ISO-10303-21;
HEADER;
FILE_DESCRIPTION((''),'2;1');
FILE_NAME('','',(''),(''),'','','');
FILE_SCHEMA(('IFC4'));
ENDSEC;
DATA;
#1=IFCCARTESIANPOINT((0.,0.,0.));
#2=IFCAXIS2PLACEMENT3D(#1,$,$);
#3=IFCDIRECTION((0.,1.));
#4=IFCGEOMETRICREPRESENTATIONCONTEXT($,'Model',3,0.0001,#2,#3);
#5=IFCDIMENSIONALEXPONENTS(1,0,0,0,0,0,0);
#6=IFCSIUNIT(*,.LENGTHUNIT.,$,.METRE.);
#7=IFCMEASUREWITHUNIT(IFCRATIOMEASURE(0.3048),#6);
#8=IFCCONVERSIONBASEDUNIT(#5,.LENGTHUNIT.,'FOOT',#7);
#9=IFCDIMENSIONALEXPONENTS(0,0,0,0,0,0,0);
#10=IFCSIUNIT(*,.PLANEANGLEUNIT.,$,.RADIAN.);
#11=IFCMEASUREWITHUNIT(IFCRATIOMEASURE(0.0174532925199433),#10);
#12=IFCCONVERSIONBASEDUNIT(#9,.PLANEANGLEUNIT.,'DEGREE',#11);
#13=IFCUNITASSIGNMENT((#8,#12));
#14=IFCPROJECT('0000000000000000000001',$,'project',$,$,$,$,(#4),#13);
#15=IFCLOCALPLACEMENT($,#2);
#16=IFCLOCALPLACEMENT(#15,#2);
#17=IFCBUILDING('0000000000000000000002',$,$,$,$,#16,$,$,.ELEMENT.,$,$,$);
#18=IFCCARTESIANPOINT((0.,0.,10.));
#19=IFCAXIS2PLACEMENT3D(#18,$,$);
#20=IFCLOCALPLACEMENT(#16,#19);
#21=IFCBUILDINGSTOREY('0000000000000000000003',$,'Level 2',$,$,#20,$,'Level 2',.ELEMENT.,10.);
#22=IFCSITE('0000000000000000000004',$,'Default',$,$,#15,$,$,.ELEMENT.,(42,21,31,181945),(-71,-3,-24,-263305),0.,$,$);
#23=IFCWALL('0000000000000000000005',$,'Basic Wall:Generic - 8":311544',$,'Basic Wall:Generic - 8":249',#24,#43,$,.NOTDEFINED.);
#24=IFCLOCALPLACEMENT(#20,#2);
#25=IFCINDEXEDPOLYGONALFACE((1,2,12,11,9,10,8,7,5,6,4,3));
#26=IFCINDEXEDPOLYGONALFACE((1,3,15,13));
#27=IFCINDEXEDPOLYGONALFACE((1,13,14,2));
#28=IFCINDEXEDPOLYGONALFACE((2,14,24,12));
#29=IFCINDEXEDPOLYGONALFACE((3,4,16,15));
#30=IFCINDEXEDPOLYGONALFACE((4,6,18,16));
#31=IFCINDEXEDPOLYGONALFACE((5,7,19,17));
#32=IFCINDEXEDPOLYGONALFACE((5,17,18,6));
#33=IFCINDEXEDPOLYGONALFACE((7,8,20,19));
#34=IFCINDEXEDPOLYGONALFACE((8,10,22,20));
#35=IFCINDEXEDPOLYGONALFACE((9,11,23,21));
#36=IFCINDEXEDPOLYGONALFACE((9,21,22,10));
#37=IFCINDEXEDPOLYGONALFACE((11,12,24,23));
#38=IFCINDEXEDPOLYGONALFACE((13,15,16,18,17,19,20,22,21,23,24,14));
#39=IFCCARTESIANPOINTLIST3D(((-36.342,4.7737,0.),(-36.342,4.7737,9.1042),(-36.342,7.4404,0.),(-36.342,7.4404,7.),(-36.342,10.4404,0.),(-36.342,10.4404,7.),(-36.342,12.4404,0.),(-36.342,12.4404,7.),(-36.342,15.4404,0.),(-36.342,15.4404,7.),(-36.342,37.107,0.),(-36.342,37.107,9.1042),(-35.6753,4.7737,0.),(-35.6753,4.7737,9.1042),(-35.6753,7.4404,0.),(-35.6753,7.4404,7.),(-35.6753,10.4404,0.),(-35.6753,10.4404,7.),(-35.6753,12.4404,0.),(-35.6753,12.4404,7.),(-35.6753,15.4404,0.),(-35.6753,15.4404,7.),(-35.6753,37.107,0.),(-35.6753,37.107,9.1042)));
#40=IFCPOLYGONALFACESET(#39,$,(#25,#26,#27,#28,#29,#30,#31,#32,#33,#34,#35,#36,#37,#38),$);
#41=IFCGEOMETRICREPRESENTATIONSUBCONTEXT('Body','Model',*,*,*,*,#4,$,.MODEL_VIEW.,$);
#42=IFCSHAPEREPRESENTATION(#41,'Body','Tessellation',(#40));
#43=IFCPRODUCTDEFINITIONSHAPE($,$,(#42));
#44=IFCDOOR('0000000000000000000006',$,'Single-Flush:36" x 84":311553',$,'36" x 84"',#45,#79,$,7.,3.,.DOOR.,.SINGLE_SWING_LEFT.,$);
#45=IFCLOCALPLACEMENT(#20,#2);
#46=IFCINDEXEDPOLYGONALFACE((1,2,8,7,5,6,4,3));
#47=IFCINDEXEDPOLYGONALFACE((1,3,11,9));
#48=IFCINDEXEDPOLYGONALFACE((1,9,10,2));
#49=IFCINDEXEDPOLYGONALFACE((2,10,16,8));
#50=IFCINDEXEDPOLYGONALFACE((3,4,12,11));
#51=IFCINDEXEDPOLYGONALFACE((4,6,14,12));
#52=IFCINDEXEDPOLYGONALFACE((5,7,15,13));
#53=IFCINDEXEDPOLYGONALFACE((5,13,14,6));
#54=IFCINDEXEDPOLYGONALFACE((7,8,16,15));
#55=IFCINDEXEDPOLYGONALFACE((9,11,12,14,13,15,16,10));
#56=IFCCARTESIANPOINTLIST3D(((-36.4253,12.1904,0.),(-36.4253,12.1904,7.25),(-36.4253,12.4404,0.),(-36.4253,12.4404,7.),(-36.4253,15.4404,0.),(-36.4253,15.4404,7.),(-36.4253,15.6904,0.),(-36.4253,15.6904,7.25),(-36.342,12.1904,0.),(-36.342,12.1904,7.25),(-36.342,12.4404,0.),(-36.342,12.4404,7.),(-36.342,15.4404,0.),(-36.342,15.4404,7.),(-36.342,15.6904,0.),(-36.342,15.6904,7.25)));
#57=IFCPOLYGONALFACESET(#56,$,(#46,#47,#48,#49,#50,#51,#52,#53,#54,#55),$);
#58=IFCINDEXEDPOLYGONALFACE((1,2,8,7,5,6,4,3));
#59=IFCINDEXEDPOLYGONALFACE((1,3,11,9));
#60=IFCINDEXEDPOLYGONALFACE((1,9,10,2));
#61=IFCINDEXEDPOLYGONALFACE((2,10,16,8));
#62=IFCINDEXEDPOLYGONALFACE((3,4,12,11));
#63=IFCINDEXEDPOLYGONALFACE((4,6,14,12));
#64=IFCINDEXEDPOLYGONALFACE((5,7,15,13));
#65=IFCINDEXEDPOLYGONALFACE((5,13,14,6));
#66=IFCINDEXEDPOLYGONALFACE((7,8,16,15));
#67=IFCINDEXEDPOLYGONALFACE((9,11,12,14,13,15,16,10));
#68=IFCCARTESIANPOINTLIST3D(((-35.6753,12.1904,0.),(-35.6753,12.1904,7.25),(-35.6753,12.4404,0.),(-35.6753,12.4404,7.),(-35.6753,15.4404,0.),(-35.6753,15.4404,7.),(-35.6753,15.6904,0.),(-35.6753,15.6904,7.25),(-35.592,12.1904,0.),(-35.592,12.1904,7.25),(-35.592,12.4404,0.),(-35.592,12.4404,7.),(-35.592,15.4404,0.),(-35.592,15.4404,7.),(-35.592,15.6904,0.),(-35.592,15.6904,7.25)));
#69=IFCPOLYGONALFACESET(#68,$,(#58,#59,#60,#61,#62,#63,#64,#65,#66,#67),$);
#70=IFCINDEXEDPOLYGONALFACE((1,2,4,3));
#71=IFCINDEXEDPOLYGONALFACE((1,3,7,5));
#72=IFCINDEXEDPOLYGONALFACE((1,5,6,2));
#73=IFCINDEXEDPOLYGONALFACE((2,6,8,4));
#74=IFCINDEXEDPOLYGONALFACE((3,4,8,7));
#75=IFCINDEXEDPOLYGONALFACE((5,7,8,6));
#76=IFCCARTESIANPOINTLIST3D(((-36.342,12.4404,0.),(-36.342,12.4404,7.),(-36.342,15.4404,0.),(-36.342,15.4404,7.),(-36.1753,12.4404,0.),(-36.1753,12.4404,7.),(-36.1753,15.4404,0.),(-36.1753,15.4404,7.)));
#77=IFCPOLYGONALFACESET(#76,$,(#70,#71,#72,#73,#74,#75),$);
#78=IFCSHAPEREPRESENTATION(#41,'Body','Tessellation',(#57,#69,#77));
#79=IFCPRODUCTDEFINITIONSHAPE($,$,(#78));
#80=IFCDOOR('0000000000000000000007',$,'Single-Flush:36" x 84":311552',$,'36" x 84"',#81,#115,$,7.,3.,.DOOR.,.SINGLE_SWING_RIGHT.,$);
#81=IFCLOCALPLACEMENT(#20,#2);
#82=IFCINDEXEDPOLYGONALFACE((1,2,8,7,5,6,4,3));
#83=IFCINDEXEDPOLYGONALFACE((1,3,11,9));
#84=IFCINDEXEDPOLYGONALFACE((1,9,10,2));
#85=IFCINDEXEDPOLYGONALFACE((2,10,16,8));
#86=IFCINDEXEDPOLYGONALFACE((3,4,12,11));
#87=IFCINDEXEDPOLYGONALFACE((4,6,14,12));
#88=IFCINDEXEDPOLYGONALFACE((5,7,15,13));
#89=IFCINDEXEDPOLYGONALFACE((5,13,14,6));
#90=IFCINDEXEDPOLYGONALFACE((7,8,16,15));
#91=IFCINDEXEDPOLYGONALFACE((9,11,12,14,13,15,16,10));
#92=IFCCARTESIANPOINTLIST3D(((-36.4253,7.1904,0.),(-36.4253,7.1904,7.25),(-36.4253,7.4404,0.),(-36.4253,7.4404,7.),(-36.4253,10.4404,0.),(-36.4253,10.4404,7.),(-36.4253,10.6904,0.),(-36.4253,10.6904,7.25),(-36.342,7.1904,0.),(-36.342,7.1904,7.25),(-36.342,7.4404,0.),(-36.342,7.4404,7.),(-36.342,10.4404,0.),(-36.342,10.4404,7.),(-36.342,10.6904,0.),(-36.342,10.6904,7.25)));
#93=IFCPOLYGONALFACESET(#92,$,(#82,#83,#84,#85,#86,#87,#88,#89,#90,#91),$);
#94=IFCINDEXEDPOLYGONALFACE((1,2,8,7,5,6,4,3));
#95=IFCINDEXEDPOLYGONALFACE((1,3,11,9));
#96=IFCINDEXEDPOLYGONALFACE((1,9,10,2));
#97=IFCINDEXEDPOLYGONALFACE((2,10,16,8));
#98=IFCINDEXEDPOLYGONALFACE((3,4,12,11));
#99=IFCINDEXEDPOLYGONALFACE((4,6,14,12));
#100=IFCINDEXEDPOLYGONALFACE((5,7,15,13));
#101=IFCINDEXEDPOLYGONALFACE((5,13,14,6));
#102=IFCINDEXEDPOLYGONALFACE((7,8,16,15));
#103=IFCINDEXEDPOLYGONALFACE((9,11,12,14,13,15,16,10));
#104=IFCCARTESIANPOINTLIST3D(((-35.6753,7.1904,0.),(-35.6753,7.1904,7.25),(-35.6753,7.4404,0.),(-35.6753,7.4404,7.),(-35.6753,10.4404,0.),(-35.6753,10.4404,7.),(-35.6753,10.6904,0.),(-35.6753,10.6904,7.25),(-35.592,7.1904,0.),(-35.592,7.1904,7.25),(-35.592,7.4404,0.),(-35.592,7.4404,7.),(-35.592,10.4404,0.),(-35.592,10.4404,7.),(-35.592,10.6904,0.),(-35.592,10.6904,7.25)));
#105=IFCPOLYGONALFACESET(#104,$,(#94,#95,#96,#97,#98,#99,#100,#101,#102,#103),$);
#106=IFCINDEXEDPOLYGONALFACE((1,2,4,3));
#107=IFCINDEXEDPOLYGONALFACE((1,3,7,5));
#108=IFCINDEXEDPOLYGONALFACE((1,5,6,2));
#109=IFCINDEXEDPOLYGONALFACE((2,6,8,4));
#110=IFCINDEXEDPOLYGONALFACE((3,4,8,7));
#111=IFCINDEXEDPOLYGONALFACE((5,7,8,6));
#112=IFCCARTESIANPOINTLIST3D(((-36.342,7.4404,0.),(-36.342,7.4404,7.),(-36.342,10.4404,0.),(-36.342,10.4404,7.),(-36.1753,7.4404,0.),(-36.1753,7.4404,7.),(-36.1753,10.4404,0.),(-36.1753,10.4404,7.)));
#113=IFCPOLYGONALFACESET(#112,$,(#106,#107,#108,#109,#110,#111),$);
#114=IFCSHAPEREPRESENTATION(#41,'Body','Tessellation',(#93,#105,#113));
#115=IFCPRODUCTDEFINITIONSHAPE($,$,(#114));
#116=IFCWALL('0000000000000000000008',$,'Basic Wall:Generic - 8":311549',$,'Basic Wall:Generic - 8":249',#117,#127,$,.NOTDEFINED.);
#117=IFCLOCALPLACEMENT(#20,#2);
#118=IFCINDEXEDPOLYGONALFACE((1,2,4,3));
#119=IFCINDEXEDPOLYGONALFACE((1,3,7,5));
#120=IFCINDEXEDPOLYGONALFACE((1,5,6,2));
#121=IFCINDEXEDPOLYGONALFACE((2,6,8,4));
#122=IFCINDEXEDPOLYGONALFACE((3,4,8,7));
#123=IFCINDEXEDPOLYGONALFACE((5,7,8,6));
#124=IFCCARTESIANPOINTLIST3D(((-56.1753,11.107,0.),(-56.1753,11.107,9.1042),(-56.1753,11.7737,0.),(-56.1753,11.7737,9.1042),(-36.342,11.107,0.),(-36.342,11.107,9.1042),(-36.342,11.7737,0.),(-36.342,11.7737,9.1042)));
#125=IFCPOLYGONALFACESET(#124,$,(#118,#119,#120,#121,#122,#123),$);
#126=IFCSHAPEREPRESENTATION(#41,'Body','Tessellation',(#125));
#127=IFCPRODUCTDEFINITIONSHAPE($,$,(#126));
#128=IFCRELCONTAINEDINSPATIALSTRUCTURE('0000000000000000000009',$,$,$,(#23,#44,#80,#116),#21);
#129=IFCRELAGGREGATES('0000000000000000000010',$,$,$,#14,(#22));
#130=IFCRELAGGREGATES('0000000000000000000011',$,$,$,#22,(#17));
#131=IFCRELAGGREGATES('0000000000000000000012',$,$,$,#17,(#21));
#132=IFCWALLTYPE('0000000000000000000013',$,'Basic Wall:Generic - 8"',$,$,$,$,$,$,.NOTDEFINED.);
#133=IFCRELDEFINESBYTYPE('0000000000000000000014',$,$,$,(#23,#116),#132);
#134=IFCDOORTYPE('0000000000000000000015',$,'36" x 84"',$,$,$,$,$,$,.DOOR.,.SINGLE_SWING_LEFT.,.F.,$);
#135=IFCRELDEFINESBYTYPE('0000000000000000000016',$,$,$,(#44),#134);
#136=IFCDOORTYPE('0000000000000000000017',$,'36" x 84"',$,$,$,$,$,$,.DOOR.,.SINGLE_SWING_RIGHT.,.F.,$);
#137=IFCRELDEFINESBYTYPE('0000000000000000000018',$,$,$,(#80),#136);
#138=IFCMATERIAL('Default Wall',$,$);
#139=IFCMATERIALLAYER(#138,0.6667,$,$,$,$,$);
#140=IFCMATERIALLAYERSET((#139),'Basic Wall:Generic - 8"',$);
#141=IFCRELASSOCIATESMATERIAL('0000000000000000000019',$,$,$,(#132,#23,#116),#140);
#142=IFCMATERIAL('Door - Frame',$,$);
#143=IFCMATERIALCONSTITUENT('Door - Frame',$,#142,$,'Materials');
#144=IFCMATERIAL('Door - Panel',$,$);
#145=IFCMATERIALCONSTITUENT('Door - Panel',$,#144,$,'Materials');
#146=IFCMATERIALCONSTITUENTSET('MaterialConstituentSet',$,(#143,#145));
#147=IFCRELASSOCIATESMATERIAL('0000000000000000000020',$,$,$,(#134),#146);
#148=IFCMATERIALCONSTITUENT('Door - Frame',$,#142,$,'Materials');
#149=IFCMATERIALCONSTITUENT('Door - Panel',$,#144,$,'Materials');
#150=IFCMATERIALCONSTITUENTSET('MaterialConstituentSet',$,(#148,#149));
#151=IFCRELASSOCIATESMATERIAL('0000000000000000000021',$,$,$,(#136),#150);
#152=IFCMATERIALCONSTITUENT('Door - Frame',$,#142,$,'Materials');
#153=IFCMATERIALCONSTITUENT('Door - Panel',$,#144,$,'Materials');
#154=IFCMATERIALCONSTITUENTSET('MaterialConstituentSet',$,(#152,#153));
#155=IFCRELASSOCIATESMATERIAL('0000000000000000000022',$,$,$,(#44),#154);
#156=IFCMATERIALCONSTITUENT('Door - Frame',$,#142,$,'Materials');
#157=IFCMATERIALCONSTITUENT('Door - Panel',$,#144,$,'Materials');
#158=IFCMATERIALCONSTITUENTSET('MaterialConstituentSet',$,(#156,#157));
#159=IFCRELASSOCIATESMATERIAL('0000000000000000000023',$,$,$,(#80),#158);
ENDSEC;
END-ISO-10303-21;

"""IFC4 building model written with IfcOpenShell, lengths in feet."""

from ifc_helpers import new_model, entity, si_unit, converted_unit, direction, frame, frame_2d, origin, place, context, subcontext, project, spatial, polyline, rectangle, outline, extrude, clip, bounded_halfspace, source, transform, mapped, material, layer, layer_set, layer_usage, constituent, constituent_set, type_object, type_shapes, element, fill, save


model = new_model("IFC4")

# Units and contexts
model_context = context("Model", 3, precision=0.0001, world=origin(), true_north=direction((0.0, 1.0)))
body_context = subcontext(model_context, "Body", "Model", "MODEL_VIEW")
ifc_project = project(units=[converted_unit("LENGTHUNIT", "FOOT", entity("IfcRatioMeasure", 0.3048), si_unit("LENGTHUNIT", "METRE"), dimensions=[1, 0, 0, 0, 0, 0, 0]), converted_unit("PLANEANGLEUNIT", "DEGREE", entity("IfcRatioMeasure", 0.0174532925199433), si_unit("PLANEANGLEUNIT", "RADIAN"), dimensions=[0, 0, 0, 0, 0, 0, 0])], contexts=[model_context])

# Site, building, storey
site_placement = place(None, origin())
site = spatial("IfcSite", under=ifc_project, at=site_placement, Name="Default", CompositionType="ELEMENT", RefLatitude=(42, 21, 31, 181945), RefLongitude=(-71, -3, -24, -263305), RefElevation=0.0)
building_placement = place(site_placement, origin())
building = spatial("IfcBuilding", under=site, at=building_placement, CompositionType="ELEMENT")
storey_placement = place(building_placement, frame((0.0, 0.0, 10.0)))
storey = spatial("IfcBuildingStorey", under=building, at=storey_placement, Name="Level 2", LongName="Level 2", CompositionType="ELEMENT", Elevation=10.0)

# Shared definitions
ifc_material_1 = material(Name="Default Wall")
ifc_layer = layer(ifc_material_1, 0.6667)
ifc_layer_set = layer_set([ifc_layer], Name="Basic Wall:Generic - 8\"")
wall_type = type_object("IfcWallType", Name="Basic Wall:Generic - 8\"", PredefinedType="NOTDEFINED", material=ifc_layer_set)

# Wall, openings, doors
ifc_material_2 = material(Name="Door - Frame")
ifc_material_3 = material(Name="Door - Panel")
ifc_constituent_1 = constituent(ifc_material_2, Name="Door - Frame", Category="Materials")
ifc_constituent_2 = constituent(ifc_material_3, Name="Door - Panel", Category="Materials")
ifc_constituent_set_1 = constituent_set(constituents=[ifc_constituent_1, ifc_constituent_2], Name="MaterialConstituentSet")
door_type_1 = type_object("IfcDoorType", Name="36\" x 84\"", OperationType="SINGLE_SWING_LEFT", ParameterTakesPrecedence=False, PredefinedType="DOOR", material=ifc_constituent_set_1)
shared_shape_1 = source(origin(), body_context, "Body", "SweptSolid", [
    extrude(outline(polyline([(-1.75, -3.6875), (1.75, -3.6875), (1.75, 3.5625), (1.5, 3.5625), (1.5, -3.4375), (-1.5, -3.4375), (-1.5, 3.5625), (-1.75, 3.5625), (-1.75, -3.6875)])), frame((1.5, 0.75, 3.5625), z_axis=(0.0, -1.0, 0.0), x_axis=(-1.0, 0.0, 0.0)), (0.0, 0.0, 1.0), 0.0833),
    extrude(outline(polyline([(-3.6875, -1.75), (3.5625, -1.75), (3.5625, -1.5), (-3.4375, -1.5), (-3.4375, 1.5), (3.5625, 1.5), (3.5625, 1.75), (-3.6875, 1.75), (-3.6875, -1.75)])), frame((1.5, 0.0, 3.5625), z_axis=(0.0, -1.0, 0.0), x_axis=(0.0, 0.0, -1.0)), (0.0, 0.0, 1.0), 0.0833),
    extrude(rectangle(XDim=3.0, YDim=0.1667, at=frame_2d((0.0, 0.0), x_axis=(1.0, 0.0))), frame((1.5, 0.5833, 0.0)), (0.0, 0.0, 1.0), 7.0),
])
type_shapes(door_type_1, [shared_shape_1])
ifc_constituent_3 = constituent(ifc_material_2, Name="Door - Frame", Category="Materials")
ifc_constituent_4 = constituent(ifc_material_3, Name="Door - Panel", Category="Materials")
ifc_constituent_set_2 = constituent_set(constituents=[ifc_constituent_3, ifc_constituent_4], Name="MaterialConstituentSet")
door_type_2 = type_object("IfcDoorType", Name="36\" x 84\"", OperationType="SINGLE_SWING_RIGHT", ParameterTakesPrecedence=False, PredefinedType="DOOR", material=ifc_constituent_set_2)
shared_shape_2 = source(origin(), body_context, "Body", "SweptSolid", [
    extrude(outline(polyline([(-1.75, -3.6875), (1.75, -3.6875), (1.75, 3.5625), (1.5, 3.5625), (1.5, -3.4375), (-1.5, -3.4375), (-1.5, 3.5625), (-1.75, 3.5625), (-1.75, -3.6875)])), frame((1.5, 0.6667, 3.5625), z_axis=(0.0, 1.0, 0.0), x_axis=(1.0, 0.0, 0.0)), (0.0, 0.0, 1.0), 0.0833),
    extrude(outline(polyline([(-3.6875, -1.75), (3.5625, -1.75), (3.5625, -1.5), (-3.4375, -1.5), (-3.4375, 1.5), (3.5625, 1.5), (3.5625, 1.75), (-3.6875, 1.75), (-3.6875, -1.75)])), frame((1.5, -0.0833, 3.5625), z_axis=(0.0, 1.0, 0.0), x_axis=(0.0, 0.0, -1.0)), (0.0, 0.0, 1.0), 0.0833),
    extrude(rectangle(XDim=0.1667, YDim=3.0, at=frame_2d((0.0, 0.0), x_axis=(1.0, 0.0))), frame((1.5, 0.5833, 0.0), z_axis=(0.0, 0.0, 1.0), x_axis=(0.0, 1.0, 0.0)), (0.0, 0.0, 1.0), 7.0),
])
type_shapes(door_type_2, [shared_shape_2])
ifc_layer_usage_1 = layer_usage(ifc_layer_set, "AXIS2", "NEGATIVE", 0.3333)
wall_1_placement = place(storey_placement, frame((-36.0087, 37.107, 0.0), z_axis=(0.0, 0.0, 1.0), x_axis=(0.0, -1.0, 0.0)))
wall_1 = element("IfcWall", 1, at=wall_1_placement, inside=storey, type_object=wall_type, material=ifc_layer_usage_1, Name="Basic Wall:Generic - 8\":311544", ObjectType="Basic Wall:Generic - 8\":249", PredefinedType="NOTDEFINED", context=body_context, shape_type="Clipping", body=[
    clip(extrude(rectangle(XDim=32.3333, YDim=0.6667, at=frame_2d((16.1667, 0.0), x_axis=(-1.0, 0.0))), origin(), (0.0, 0.0, 1.0), 9.1042), bounded_halfspace(frame((0.0, -0.3333, 9.1042), z_axis=(0.0, 0.0, -1.0), x_axis=(1.0, 0.0, 0.0)), True, frame((0.0, -0.3333, 9.1042), z_axis=(0.0, 0.0, -1.0), x_axis=(1.0, 0.0, 0.0)), polyline([(0.0, 0.0), (0.0, -0.6667), (32.3333, -0.6667), (32.3333, 0.0), (26.0, 0.0), (25.3333, 0.0), (0.0, 0.0)]))),
])
opening_1_placement = place(wall_1_placement, frame((29.6667, 0.3333, 0.0)))
opening_1 = element("IfcOpeningElement", 2, at=opening_1_placement, cuts=wall_1, ObjectType="Opening", PredefinedType="OPENING", context=body_context, shape_type="SweptSolid", body=[
    extrude(rectangle(XDim=3.0, YDim=7.0, at=frame_2d((3.5, 1.5), x_axis=(0.0, 1.0))), frame((0.0, 0.0, 0.0), z_axis=(0.0, -1.0, 0.0), x_axis=(0.0, 0.0, 1.0)), (0.0, 0.0, 1.0), 0.6667),
])
opening_2_placement = place(wall_1_placement, frame((24.6667, 0.3333, 0.0)))
opening_2 = element("IfcOpeningElement", 3, at=opening_2_placement, cuts=wall_1, ObjectType="Opening", PredefinedType="OPENING", context=body_context, shape_type="SweptSolid", body=[
    extrude(rectangle(XDim=3.0, YDim=7.0, at=frame_2d((3.5, 1.5), x_axis=(0.0, -1.0))), frame((0.0, 0.0, 0.0), z_axis=(0.0, -1.0, 0.0), x_axis=(0.0, 0.0, 1.0)), (0.0, 0.0, 1.0), 0.6667),
])
ifc_constituent_5 = constituent(ifc_material_2, Name="Door - Frame", Category="Materials")
ifc_constituent_6 = constituent(ifc_material_3, Name="Door - Panel", Category="Materials")
ifc_constituent_set_3 = constituent_set(constituents=[ifc_constituent_5, ifc_constituent_6], Name="MaterialConstituentSet")
door_1_placement = place(opening_2_placement, frame((0.0, 0.0, 0.0), z_axis=(0.0, 0.0, 1.0), x_axis=(-1.0, 0.0, 0.0)))
door_1 = element("IfcDoor", 4, at=door_1_placement, inside=storey, type_object=door_type_1, material=ifc_constituent_set_3, Name="Single-Flush:36\" x 84\":311553", ObjectType="36\" x 84\"", OperationType="SINGLE_SWING_LEFT", OverallHeight=7.0, OverallWidth=3.0, PredefinedType="DOOR", context=body_context, shape_type="MappedRepresentation", body=[
    mapped(shared_shape_1, transform((0.0, 0.0, 0.0), scale=1.0)),
])
fill(opening_2, door_1)
ifc_constituent_7 = constituent(ifc_material_2, Name="Door - Frame", Category="Materials")
ifc_constituent_8 = constituent(ifc_material_3, Name="Door - Panel", Category="Materials")
ifc_constituent_set_4 = constituent_set(constituents=[ifc_constituent_7, ifc_constituent_8], Name="MaterialConstituentSet")
door_2_placement = place(opening_1_placement, frame((0.0, 0.0, 0.0), z_axis=(0.0, 0.0, 1.0), x_axis=(-1.0, 0.0, 0.0)))
door_2 = element("IfcDoor", 5, at=door_2_placement, inside=storey, type_object=door_type_2, material=ifc_constituent_set_4, Name="Single-Flush:36\" x 84\":311552", ObjectType="36\" x 84\"", OperationType="SINGLE_SWING_RIGHT", OverallHeight=7.0, OverallWidth=3.0, PredefinedType="DOOR", context=body_context, shape_type="MappedRepresentation", body=[
    mapped(shared_shape_2, transform((0.0, 0.0, 0.0), scale=1.0)),
])
fill(opening_1, door_2)

# Wall
ifc_layer_usage_2 = layer_usage(ifc_layer_set, "AXIS2", "NEGATIVE", 0.3333)
wall_2_placement = place(storey_placement, frame((-36.342, 11.4404, 0.0), z_axis=(0.0, 0.0, 1.0), x_axis=(-1.0, 0.0, 0.0)))
element("IfcWall", 6, at=wall_2_placement, inside=storey, type_object=wall_type, material=ifc_layer_usage_2, Name="Basic Wall:Generic - 8\":311549", ObjectType="Basic Wall:Generic - 8\":249", PredefinedType="NOTDEFINED", context=body_context, shape_type="Clipping", body=[
    clip(extrude(rectangle(XDim=19.8333, YDim=0.6667, at=frame_2d((9.9167, 0.0), x_axis=(-1.0, 0.0))), origin(), (0.0, 0.0, 1.0), 9.1042), bounded_halfspace(frame((0.0, -0.3333, 9.1042), z_axis=(0.0, 0.0, -1.0), x_axis=(0.0, 1.0, 0.0)), True, frame((0.0, -0.3333, 9.1042), z_axis=(0.0, 0.0, -1.0), x_axis=(0.0, 1.0, 0.0)), polyline([(0.0, 0.0), (0.6667, 0.0), (0.6667, 19.8333), (0.0, 19.8333), (0.0, 0.0)]))),
])

save(model, "model.ifc")
